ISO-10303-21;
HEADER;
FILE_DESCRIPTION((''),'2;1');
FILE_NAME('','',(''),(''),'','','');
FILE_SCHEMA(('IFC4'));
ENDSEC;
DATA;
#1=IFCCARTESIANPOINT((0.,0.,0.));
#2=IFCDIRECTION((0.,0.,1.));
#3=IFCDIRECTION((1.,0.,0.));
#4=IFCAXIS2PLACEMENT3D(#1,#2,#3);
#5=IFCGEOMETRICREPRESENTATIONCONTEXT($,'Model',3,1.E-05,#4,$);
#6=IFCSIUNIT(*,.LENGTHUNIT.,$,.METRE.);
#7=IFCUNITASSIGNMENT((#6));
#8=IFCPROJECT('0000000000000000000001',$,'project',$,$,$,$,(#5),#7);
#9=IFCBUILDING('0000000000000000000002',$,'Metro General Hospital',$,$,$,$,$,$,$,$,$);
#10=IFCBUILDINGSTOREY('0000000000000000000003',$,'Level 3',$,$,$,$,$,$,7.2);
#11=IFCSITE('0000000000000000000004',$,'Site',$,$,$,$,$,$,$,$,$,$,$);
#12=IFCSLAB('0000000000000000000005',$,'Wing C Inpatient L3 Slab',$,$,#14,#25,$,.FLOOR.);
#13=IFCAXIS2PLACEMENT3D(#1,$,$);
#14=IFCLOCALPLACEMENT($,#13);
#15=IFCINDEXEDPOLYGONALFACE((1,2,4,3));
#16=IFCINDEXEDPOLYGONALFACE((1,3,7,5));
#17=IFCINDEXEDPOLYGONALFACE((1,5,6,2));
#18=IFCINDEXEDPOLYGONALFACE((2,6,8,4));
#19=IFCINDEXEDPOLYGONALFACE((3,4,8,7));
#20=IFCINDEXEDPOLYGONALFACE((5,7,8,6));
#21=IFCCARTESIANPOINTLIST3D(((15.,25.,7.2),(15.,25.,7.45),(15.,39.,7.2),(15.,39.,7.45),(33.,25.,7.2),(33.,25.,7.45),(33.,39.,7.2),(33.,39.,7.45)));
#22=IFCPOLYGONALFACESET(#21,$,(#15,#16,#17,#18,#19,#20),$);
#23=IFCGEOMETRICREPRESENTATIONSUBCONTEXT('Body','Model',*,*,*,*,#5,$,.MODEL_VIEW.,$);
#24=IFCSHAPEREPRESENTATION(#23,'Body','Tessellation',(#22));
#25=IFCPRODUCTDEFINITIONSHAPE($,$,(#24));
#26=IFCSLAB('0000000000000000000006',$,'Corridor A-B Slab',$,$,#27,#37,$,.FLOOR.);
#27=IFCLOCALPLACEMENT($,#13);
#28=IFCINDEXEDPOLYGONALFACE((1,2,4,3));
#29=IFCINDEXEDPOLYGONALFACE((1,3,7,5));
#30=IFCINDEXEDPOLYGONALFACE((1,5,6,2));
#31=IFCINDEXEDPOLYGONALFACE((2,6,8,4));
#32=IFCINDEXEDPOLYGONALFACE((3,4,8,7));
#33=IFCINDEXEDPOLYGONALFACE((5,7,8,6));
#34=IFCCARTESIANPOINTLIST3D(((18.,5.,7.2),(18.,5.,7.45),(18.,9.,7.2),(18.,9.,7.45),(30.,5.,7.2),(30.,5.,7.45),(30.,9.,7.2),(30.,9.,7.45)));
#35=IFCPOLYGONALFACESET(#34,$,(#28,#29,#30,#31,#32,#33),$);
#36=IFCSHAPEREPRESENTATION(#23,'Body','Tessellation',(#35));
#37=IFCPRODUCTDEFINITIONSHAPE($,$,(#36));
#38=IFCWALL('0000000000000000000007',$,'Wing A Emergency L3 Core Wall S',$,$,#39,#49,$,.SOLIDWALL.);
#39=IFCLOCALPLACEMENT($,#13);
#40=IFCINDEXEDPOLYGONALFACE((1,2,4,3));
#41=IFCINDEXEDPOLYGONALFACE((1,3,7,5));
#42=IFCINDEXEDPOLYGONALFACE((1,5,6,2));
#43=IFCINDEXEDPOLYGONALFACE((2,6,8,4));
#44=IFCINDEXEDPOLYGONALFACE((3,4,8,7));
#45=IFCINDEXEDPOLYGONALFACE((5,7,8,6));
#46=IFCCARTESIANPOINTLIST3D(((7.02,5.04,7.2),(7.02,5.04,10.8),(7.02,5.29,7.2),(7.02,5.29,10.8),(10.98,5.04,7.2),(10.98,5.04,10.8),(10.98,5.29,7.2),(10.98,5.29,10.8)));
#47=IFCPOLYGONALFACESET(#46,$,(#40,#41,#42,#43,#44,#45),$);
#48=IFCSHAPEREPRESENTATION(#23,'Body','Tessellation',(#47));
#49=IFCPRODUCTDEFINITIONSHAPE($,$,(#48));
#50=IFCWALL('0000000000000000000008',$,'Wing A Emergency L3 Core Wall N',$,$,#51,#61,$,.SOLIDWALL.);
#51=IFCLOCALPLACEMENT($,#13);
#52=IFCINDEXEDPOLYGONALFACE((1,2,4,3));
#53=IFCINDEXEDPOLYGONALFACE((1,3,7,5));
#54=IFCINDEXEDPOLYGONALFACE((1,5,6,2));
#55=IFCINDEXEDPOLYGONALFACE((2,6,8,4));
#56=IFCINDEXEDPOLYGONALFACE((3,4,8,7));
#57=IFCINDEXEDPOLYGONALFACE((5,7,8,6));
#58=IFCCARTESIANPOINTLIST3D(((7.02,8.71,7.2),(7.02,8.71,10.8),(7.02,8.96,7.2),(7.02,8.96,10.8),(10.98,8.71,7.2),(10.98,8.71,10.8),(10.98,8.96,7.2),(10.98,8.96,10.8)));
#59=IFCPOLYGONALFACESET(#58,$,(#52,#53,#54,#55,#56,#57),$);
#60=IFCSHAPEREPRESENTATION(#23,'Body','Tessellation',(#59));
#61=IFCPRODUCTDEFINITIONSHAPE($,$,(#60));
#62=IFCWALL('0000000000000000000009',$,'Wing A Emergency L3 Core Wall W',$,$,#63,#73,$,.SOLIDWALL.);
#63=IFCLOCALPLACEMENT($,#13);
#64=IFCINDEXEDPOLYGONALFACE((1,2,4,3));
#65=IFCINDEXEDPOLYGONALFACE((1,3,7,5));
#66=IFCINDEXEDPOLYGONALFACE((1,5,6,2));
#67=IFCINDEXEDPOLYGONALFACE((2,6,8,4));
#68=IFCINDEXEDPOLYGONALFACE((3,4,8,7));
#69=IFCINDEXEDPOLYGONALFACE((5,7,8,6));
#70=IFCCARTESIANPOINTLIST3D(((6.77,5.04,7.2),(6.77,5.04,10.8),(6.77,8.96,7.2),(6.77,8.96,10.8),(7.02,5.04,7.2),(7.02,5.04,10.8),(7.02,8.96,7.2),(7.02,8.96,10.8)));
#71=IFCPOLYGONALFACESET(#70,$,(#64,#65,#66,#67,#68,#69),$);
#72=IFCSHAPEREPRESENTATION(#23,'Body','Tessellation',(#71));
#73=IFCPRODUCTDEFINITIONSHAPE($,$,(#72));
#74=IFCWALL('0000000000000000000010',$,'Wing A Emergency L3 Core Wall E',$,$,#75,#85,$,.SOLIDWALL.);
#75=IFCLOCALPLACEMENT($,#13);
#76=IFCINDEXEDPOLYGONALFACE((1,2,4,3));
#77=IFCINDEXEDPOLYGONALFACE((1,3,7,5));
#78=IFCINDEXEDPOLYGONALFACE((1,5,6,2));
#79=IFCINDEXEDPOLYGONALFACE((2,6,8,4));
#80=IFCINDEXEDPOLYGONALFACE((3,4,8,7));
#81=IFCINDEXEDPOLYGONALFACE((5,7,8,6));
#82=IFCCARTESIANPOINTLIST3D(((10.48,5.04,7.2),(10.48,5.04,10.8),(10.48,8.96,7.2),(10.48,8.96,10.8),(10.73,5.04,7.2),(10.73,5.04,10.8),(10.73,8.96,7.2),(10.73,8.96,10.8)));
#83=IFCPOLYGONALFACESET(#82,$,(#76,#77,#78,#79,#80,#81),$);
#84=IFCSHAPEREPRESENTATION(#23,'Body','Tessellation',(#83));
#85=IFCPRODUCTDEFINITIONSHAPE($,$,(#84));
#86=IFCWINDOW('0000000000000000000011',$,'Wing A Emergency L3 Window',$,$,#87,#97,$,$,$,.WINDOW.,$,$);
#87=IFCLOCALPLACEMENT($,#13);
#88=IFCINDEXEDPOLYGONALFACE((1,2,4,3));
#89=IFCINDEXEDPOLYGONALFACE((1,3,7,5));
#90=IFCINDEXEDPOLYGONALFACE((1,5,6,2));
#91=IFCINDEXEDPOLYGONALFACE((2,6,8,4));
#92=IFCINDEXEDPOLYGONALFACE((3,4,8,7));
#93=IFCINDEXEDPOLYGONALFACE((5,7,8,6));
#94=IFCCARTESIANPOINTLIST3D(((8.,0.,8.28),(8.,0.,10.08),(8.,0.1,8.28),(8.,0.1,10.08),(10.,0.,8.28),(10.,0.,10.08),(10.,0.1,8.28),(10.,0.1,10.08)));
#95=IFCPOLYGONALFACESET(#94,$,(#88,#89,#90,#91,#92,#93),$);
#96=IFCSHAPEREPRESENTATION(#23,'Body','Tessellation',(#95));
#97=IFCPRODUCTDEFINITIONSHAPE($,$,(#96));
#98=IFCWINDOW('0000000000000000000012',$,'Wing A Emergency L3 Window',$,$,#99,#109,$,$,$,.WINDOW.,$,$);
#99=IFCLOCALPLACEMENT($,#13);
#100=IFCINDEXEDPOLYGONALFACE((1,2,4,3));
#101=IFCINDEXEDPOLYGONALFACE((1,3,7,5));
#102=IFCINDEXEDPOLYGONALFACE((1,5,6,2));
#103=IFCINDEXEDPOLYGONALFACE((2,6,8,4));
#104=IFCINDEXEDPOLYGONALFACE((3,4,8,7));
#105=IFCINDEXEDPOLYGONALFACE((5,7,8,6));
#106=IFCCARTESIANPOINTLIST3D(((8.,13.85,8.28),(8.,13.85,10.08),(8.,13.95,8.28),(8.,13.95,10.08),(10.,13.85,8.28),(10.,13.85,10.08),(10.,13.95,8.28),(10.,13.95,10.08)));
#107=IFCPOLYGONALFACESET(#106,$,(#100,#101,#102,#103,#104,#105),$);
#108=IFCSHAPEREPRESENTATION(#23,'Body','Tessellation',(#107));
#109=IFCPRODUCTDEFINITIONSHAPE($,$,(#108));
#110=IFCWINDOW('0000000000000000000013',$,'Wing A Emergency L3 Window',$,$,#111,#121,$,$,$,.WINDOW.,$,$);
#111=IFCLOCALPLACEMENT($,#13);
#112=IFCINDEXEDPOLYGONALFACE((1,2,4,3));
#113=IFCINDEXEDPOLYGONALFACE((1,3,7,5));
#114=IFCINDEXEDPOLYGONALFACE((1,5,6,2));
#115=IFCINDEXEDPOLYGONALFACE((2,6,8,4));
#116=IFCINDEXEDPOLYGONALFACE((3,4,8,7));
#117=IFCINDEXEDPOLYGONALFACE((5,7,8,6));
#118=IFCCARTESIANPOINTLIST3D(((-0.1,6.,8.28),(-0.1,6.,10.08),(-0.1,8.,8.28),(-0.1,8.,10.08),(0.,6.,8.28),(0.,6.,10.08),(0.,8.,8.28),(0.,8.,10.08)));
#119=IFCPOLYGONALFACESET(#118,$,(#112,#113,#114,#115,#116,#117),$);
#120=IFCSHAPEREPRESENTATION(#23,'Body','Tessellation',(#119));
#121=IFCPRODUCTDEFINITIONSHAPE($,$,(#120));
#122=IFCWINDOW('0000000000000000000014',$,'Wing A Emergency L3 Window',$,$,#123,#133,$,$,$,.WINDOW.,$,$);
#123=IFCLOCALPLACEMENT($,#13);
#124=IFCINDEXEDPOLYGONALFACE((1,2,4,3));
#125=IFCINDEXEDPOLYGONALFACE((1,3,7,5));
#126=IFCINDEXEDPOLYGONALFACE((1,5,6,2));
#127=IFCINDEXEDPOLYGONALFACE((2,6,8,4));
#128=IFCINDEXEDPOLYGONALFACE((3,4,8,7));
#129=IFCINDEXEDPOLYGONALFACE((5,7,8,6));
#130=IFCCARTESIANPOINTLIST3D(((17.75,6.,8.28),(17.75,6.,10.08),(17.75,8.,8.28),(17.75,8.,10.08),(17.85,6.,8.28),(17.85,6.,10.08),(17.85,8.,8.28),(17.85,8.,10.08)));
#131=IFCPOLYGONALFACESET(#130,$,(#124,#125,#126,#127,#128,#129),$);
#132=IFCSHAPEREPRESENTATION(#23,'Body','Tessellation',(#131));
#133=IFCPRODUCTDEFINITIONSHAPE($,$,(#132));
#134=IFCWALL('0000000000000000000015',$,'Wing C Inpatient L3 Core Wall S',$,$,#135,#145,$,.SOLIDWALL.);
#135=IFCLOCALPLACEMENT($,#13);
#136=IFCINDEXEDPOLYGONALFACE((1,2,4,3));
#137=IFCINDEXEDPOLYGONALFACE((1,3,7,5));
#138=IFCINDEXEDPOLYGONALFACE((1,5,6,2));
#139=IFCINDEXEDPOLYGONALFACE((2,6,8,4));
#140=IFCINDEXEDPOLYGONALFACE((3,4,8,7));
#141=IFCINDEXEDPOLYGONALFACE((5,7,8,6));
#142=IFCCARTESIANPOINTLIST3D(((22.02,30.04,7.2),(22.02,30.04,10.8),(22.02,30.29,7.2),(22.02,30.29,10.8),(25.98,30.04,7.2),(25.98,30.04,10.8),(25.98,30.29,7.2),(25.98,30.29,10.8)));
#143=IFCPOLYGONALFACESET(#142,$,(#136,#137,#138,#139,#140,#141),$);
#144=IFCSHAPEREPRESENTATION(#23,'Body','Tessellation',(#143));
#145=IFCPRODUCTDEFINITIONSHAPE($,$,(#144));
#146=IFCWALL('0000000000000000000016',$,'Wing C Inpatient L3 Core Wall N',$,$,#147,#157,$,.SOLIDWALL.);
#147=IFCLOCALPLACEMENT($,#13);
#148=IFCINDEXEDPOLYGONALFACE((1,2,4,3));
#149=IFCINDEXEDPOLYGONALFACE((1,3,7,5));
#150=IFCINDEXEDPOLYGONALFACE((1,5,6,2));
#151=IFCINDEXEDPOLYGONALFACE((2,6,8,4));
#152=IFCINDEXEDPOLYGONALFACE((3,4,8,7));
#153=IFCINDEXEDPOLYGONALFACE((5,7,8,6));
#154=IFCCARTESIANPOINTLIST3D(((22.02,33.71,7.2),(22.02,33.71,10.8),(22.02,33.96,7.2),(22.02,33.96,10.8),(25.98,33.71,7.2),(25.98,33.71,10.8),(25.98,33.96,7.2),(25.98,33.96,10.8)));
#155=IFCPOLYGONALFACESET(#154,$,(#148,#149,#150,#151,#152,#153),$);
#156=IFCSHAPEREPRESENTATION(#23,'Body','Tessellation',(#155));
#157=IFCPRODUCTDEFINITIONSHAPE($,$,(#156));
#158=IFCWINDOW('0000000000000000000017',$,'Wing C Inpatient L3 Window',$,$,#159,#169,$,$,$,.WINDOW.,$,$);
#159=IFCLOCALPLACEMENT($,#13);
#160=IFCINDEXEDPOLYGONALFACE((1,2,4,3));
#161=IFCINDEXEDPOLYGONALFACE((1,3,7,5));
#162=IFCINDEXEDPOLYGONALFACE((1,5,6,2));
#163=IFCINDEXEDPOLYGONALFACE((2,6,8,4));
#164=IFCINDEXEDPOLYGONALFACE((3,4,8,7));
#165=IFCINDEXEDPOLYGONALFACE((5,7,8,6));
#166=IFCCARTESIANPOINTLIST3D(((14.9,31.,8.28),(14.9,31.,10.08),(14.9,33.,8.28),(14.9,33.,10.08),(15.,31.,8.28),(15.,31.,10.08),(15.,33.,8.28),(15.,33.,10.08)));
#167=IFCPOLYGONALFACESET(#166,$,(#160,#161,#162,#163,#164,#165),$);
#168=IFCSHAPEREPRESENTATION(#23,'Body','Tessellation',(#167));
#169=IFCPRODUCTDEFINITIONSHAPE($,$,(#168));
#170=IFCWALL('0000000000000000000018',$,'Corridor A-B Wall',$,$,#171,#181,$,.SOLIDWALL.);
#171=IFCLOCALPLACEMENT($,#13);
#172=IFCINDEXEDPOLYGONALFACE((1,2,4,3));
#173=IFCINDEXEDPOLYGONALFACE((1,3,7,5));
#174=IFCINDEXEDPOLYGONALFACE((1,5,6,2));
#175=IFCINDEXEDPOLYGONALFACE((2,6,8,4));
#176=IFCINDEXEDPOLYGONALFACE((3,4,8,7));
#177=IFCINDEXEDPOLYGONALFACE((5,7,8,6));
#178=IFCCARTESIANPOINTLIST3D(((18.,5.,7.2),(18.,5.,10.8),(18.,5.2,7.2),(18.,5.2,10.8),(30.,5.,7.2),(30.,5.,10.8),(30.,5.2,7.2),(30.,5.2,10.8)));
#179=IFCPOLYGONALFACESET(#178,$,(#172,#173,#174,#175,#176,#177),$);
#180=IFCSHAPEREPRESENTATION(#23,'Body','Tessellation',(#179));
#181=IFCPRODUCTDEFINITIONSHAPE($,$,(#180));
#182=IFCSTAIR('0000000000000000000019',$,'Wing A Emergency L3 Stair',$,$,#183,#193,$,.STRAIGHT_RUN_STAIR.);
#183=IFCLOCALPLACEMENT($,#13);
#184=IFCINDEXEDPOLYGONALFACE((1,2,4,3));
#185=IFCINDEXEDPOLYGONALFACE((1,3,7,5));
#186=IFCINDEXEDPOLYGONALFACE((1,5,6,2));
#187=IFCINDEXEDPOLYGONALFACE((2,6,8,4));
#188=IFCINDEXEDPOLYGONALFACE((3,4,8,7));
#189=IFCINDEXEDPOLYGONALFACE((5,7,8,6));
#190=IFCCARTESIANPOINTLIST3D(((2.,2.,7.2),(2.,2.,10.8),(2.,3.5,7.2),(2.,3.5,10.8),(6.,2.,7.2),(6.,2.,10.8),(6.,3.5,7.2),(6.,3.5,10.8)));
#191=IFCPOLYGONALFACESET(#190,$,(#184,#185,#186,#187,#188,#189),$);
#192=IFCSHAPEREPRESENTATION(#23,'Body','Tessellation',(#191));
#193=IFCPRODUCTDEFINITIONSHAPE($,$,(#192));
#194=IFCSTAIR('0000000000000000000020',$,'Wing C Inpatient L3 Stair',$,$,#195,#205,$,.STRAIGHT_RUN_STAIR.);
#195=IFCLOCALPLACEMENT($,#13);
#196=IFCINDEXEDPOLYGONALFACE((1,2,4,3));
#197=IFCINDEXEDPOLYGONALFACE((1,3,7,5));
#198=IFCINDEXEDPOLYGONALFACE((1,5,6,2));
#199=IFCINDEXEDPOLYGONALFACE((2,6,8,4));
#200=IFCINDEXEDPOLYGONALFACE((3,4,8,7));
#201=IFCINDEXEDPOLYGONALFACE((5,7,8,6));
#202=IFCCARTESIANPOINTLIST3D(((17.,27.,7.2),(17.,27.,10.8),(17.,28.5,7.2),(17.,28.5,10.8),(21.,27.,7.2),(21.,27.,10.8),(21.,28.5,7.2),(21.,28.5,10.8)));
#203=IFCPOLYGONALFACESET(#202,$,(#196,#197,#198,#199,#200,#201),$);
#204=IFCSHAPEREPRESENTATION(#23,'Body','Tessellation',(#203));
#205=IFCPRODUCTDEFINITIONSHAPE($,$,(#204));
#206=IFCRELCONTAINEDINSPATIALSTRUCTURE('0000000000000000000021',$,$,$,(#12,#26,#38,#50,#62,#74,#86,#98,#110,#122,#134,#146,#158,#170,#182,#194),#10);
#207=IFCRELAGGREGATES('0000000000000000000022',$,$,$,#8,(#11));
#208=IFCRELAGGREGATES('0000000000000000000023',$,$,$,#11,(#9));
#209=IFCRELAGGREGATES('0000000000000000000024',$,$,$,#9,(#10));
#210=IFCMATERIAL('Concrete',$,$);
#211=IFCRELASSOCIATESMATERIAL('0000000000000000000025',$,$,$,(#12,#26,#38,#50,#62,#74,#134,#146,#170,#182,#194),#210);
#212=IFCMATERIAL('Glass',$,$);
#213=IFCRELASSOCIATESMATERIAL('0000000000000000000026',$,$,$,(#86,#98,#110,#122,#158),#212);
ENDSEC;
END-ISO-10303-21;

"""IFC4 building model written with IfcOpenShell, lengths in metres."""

from ifc_helpers import new_model, si_unit, frame, origin_with_axes, place, context, subcontext, project, spatial, line, indexed_curve, outline, extrude, material, element, save


model = new_model("IFC4")

# Units and contexts
model_context = context("Model", 3, precision=1e-05, world=origin_with_axes())
body_context = subcontext(model_context, "Body", "Model", "MODEL_VIEW")
ifc_project = project(units=[si_unit("LENGTHUNIT", "METRE")], contexts=[model_context])

# Site, building, storey
site = spatial("IfcSite", under=ifc_project, Name="Site")
building = spatial("IfcBuilding", under=site, Name="Metro General Hospital")
storey = spatial("IfcBuildingStorey", under=building, Name="Level 3", Elevation=7.2)

# Slabs
ifc_material_1 = material(Name="Concrete")
for number, where, z_axis, x_axis, name in (
    (1, (15.0, 25.0, 7.2), (0.0, 0.0, 1.0), (1.0, 0.0, 0.0), "Wing C Inpatient L3 Slab"),
):
    element("IfcSlab", number, at=place(None, frame(where, z_axis=z_axis, x_axis=x_axis)), inside=storey, material=ifc_material_1, Name=name, PredefinedType="FLOOR", context=body_context, shape_type="SweptSolid", body=[
        extrude(outline(indexed_curve([(0.0, 0.0), (18.0, 0.0), (18.0, 14.0), (0.0, 14.0)], segments=[line(1, 2, 3, 4, 1)])), origin_with_axes(), (0.0, 0.0, 1.0), 0.25),
    ])
slab_placement = place(None, frame((18.0, 5.0, 7.2), z_axis=(0.0, 0.0, 1.0), x_axis=(1.0, 0.0, 0.0)))
element("IfcSlab", 2, at=slab_placement, inside=storey, material=ifc_material_1, Name="Corridor A-B Slab", PredefinedType="FLOOR", context=body_context, shape_type="SweptSolid", body=[
    extrude(outline(indexed_curve([(0.0, 0.0), (12.0, 0.0), (12.0, 4.0), (0.0, 4.0)], segments=[line(1, 2, 3, 4, 1)])), origin_with_axes(), (0.0, 0.0, 1.0), 0.25),
])

# Walls
for number, where, z_axis, x_axis, name in (
    (3, (7.02, 5.04, 7.2), (0.0, 0.0, 1.0), (1.0, 0.0, 0.0), "Wing A Emergency L3 Core Wall S"),
    (4, (7.02, 8.71, 7.2), (0.0, 0.0, 1.0), (1.0, 0.0, 0.0), "Wing A Emergency L3 Core Wall N"),
):
    element("IfcWall", number, at=place(None, frame(where, z_axis=z_axis, x_axis=x_axis)), inside=storey, material=ifc_material_1, Name=name, PredefinedType="SOLIDWALL", context=body_context, shape_type="SweptSolid", body=[
        extrude(outline(indexed_curve([(0.0, 0.0), (3.96, 0.0), (3.96, 0.25), (0.0, 0.25)], segments=[line(1, 2, 3, 4, 1)])), origin_with_axes(), (0.0, 0.0, 1.0), 3.6),
    ])
for number, where, z_axis, x_axis, name in (
    (5, (7.02, 5.04, 7.2), (0.0, 0.0, 1.0), (0.0, 1.0, 0.0), "Wing A Emergency L3 Core Wall W"),
    (6, (10.73, 5.04, 7.2), (0.0, 0.0, 1.0), (0.0, 1.0, 0.0), "Wing A Emergency L3 Core Wall E"),
):
    element("IfcWall", number, at=place(None, frame(where, z_axis=z_axis, x_axis=x_axis)), inside=storey, material=ifc_material_1, Name=name, PredefinedType="SOLIDWALL", context=body_context, shape_type="SweptSolid", body=[
        extrude(outline(indexed_curve([(0.0, 0.0), (3.92, 0.0), (3.92, 0.25), (0.0, 0.25)], segments=[line(1, 2, 3, 4, 1)])), origin_with_axes(), (0.0, 0.0, 1.0), 3.6),
    ])

# Windows
ifc_material_2 = material(Name="Glass")
for number, where, z_axis, x_axis, name in (
    (7, (8.0, 0.0, 8.28), (0.0, 0.0, 1.0), (1.0, 0.0, 0.0), "Wing A Emergency L3 Window"),
    (8, (8.0, 13.85, 8.28), (0.0, 0.0, 1.0), (1.0, 0.0, 0.0), "Wing A Emergency L3 Window"),
    (9, (0.0, 6.0, 8.28), (0.0, 0.0, 1.0), (0.0, 1.0, 0.0), "Wing A Emergency L3 Window"),
    (10, (17.85, 6.0, 8.28), (0.0, 0.0, 1.0), (0.0, 1.0, 0.0), "Wing A Emergency L3 Window"),
):
    element("IfcWindow", number, at=place(None, frame(where, z_axis=z_axis, x_axis=x_axis)), inside=storey, material=ifc_material_2, Name=name, PredefinedType="WINDOW", context=body_context, shape_type="SweptSolid", body=[
        extrude(outline(indexed_curve([(0.0, 0.0), (2.0, 0.0), (2.0, 0.1), (0.0, 0.1)], segments=[line(1, 2, 3, 4, 1)])), origin_with_axes(), (0.0, 0.0, 1.0), 1.8),
    ])

# Walls
for number, where, z_axis, x_axis, name in (
    (11, (22.02, 30.04, 7.2), (0.0, 0.0, 1.0), (1.0, 0.0, 0.0), "Wing C Inpatient L3 Core Wall S"),
    (12, (22.02, 33.71, 7.2), (0.0, 0.0, 1.0), (1.0, 0.0, 0.0), "Wing C Inpatient L3 Core Wall N"),
):
    element("IfcWall", number, at=place(None, frame(where, z_axis=z_axis, x_axis=x_axis)), inside=storey, material=ifc_material_1, Name=name, PredefinedType="SOLIDWALL", context=body_context, shape_type="SweptSolid", body=[
        extrude(outline(indexed_curve([(0.0, 0.0), (3.96, 0.0), (3.96, 0.25), (0.0, 0.25)], segments=[line(1, 2, 3, 4, 1)])), origin_with_axes(), (0.0, 0.0, 1.0), 3.6),
    ])

# Window
window_placement = place(None, frame((15.0, 31.0, 8.28), z_axis=(0.0, 0.0, 1.0), x_axis=(0.0, 1.0, 0.0)))
element("IfcWindow", 13, at=window_placement, inside=storey, material=ifc_material_2, Name="Wing C Inpatient L3 Window", PredefinedType="WINDOW", context=body_context, shape_type="SweptSolid", body=[
    extrude(outline(indexed_curve([(0.0, 0.0), (2.0, 0.0), (2.0, 0.1), (0.0, 0.1)], segments=[line(1, 2, 3, 4, 1)])), origin_with_axes(), (0.0, 0.0, 1.0), 1.8),
])

# Wall
wall_placement = place(None, frame((18.0, 5.0, 7.2), z_axis=(0.0, 0.0, 1.0), x_axis=(1.0, 0.0, 0.0)))
element("IfcWall", 14, at=wall_placement, inside=storey, material=ifc_material_1, Name="Corridor A-B Wall", PredefinedType="SOLIDWALL", context=body_context, shape_type="SweptSolid", body=[
    extrude(outline(indexed_curve([(0.0, 0.0), (12.0, 0.0), (12.0, 0.2), (0.0, 0.2)], segments=[line(1, 2, 3, 4, 1)])), origin_with_axes(), (0.0, 0.0, 1.0), 3.6),
])

# Stairs
for number, where, z_axis, x_axis, name in (
    (15, (2.0, 2.0, 7.2), (0.0, 0.0, 1.0), (1.0, 0.0, 0.0), "Wing A Emergency L3 Stair"),
    (16, (17.0, 27.0, 7.2), (0.0, 0.0, 1.0), (1.0, 0.0, 0.0), "Wing C Inpatient L3 Stair"),
):
    element("IfcStair", number, at=place(None, frame(where, z_axis=z_axis, x_axis=x_axis)), inside=storey, material=ifc_material_1, Name=name, PredefinedType="STRAIGHT_RUN_STAIR", context=body_context, shape_type="SweptSolid", body=[
        extrude(outline(indexed_curve([(0.0, 0.0), (4.0, 0.0), (4.0, 1.5), (0.0, 1.5)], segments=[line(1, 2, 3, 4, 1)])), origin_with_axes(), (0.0, 0.0, 1.0), 3.6),
    ])

save(model, "model.ifc")
